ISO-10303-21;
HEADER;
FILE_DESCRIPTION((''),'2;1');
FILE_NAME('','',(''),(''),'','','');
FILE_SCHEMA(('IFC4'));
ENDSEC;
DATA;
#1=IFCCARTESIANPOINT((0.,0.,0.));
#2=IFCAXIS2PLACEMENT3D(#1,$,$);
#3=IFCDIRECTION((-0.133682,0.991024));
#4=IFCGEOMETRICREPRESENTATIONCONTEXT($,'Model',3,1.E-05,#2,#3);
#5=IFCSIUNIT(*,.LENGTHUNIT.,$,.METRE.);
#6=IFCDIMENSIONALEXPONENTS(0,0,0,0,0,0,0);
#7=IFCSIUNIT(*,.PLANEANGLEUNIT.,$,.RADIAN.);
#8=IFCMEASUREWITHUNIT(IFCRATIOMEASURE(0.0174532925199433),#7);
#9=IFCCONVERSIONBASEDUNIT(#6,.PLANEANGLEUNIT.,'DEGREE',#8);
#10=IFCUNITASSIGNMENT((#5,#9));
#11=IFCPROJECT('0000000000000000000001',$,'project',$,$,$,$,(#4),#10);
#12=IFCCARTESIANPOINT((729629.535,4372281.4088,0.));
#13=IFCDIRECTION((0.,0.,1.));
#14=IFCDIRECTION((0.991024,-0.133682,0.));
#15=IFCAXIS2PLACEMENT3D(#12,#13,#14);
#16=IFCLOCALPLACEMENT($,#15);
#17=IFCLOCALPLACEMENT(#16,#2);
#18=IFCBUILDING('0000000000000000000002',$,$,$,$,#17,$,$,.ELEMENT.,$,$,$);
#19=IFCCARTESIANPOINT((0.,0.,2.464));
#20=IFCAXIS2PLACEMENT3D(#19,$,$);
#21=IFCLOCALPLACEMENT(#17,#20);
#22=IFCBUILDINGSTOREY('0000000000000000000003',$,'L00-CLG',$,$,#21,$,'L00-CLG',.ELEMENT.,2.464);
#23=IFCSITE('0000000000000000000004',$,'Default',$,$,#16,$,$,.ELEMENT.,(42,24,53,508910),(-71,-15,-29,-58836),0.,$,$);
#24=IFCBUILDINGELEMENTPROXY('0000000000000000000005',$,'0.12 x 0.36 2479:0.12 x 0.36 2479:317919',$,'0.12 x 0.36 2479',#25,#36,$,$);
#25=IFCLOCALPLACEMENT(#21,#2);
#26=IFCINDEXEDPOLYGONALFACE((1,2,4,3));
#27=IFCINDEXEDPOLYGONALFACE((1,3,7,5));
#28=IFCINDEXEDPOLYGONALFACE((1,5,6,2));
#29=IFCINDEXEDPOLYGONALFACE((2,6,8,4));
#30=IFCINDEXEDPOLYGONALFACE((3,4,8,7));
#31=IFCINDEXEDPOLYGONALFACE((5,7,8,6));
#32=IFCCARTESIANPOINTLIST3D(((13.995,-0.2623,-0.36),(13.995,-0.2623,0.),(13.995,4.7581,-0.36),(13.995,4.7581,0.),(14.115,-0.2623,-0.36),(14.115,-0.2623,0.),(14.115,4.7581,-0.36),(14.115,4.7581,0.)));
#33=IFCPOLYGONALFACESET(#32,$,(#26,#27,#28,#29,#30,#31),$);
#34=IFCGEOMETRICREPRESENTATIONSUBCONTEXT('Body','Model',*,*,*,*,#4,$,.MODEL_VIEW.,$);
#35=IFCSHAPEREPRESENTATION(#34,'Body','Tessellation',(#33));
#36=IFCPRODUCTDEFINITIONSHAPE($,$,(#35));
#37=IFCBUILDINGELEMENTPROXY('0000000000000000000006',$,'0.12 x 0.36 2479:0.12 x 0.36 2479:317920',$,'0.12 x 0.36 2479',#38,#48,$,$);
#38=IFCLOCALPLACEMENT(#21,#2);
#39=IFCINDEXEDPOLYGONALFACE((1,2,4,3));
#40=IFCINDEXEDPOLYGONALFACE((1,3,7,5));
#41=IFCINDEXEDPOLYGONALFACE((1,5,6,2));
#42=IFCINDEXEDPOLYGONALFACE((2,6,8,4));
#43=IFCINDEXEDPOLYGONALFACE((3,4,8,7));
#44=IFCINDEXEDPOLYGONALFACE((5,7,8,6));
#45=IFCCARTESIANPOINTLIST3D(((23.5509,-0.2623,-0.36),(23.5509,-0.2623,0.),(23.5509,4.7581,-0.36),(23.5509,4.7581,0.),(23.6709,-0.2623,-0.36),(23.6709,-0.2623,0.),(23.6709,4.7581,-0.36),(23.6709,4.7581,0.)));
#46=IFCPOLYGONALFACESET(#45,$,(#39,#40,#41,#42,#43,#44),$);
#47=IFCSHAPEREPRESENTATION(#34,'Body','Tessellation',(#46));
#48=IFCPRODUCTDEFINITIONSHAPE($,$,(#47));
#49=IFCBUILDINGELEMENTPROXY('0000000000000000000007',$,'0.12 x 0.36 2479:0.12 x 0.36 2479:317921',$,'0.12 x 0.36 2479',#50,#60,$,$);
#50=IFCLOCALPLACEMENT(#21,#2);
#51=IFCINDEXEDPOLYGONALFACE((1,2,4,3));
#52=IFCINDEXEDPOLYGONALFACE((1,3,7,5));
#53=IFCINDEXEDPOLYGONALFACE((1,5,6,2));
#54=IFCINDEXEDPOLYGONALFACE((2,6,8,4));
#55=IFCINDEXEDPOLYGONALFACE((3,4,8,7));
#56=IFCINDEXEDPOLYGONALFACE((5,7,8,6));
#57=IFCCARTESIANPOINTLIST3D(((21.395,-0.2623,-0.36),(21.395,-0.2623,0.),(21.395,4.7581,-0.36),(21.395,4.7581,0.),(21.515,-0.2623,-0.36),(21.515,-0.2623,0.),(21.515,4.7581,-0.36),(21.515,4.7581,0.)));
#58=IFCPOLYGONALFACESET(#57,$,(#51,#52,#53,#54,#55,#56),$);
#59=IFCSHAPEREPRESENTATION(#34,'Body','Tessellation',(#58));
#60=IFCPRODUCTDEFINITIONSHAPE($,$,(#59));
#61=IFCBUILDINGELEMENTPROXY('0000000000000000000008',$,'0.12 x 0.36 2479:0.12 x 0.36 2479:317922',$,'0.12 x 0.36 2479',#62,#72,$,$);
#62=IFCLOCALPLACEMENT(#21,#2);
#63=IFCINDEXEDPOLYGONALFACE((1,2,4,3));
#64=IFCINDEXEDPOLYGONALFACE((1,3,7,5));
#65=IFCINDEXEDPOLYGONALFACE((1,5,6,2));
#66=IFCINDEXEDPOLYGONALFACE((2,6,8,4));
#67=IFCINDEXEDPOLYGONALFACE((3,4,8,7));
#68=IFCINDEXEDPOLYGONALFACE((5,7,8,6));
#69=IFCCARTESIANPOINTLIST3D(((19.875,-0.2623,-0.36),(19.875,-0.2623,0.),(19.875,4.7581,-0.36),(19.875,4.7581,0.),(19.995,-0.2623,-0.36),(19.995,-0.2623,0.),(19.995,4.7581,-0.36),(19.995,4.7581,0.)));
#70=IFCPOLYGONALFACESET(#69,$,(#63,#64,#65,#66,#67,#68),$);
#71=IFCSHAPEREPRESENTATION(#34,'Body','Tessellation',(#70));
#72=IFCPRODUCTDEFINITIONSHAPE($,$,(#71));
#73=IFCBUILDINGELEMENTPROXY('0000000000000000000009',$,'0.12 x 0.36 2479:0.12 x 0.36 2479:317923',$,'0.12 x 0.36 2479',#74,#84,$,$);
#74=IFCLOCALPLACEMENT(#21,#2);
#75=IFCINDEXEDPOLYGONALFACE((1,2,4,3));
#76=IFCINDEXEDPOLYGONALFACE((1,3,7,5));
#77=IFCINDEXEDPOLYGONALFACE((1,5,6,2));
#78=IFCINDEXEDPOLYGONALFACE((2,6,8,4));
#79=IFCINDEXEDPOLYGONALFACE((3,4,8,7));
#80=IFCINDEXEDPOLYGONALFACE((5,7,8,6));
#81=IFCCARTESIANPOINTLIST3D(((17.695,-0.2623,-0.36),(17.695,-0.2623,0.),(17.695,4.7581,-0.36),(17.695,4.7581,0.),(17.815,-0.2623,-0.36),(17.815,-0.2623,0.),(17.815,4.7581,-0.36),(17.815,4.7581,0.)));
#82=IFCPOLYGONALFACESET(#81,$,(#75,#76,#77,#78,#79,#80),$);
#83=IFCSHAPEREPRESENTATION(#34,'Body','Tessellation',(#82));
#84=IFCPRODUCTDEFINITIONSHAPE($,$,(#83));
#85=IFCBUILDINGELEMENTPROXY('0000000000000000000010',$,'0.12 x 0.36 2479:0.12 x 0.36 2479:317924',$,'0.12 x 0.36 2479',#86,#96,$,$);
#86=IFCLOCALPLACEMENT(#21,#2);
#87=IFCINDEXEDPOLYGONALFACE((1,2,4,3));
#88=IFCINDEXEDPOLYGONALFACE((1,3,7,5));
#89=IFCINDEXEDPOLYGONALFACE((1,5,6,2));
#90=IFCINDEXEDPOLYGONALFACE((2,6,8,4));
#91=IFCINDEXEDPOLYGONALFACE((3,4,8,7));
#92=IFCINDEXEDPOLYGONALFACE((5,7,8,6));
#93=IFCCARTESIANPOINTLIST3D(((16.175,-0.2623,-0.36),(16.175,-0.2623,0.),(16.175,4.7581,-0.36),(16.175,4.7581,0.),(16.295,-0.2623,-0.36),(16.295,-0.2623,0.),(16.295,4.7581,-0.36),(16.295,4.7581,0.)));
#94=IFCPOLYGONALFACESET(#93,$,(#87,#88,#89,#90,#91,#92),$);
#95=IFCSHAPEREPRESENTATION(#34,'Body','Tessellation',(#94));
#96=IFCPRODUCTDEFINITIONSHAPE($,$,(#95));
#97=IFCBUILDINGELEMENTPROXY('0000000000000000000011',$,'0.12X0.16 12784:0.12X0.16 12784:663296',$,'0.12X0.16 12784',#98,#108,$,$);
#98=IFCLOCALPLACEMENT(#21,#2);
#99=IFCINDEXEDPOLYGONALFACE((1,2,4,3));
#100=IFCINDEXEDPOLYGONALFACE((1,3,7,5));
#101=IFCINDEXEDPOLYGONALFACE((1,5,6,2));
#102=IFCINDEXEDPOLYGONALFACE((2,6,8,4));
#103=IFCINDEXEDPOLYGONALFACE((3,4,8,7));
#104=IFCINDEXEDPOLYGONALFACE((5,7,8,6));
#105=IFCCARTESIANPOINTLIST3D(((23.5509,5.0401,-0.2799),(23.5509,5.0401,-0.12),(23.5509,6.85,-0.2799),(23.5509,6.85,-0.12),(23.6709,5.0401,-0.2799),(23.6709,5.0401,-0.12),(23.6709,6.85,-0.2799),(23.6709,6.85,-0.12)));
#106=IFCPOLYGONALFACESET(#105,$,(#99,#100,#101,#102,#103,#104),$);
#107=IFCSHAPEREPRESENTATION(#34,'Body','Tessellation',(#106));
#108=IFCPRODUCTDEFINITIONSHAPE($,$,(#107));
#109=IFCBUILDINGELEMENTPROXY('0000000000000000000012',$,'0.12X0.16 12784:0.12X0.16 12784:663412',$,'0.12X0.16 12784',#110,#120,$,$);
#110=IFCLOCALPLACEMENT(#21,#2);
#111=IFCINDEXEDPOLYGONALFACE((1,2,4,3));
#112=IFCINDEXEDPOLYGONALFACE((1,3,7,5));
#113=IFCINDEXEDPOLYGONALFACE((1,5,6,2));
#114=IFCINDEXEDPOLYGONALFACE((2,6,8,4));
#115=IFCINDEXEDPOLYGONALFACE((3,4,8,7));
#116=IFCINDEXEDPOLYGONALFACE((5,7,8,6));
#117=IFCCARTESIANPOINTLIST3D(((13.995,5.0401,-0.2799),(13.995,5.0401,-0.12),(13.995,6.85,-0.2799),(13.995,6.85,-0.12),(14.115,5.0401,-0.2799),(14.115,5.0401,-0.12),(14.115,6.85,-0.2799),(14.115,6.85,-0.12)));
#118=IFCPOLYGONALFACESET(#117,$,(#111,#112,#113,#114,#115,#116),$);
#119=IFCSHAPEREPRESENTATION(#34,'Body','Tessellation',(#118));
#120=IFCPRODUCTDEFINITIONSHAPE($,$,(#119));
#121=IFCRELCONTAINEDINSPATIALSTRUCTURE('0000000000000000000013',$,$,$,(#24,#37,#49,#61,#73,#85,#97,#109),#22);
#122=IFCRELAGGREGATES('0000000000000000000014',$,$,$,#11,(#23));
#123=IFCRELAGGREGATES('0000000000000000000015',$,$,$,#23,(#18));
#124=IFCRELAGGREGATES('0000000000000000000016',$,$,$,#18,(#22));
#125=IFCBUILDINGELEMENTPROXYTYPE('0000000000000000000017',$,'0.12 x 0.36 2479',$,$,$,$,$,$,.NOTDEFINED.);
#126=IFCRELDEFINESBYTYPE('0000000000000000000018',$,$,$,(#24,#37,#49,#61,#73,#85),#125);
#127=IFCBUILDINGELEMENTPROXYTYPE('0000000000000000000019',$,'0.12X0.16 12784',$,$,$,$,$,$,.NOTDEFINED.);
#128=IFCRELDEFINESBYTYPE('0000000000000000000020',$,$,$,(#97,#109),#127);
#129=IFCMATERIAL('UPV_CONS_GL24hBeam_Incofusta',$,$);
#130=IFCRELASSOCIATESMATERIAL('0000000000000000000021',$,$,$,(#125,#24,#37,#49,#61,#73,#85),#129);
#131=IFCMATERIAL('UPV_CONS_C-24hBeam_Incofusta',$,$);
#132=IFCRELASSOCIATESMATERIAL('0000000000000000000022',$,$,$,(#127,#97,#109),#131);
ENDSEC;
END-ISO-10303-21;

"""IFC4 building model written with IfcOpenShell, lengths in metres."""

from ifc_helpers import new_model, entity, si_unit, converted_unit, direction, frame, frame_2d, origin, origin_2d_with_axis, place, context, subcontext, project, spatial, rectangle, extrude, source, transform, mapped, material, type_object, type_shapes, element, save


model = new_model("IFC4")

# Units and contexts
model_context = context("Model", 3, precision=1e-05, world=origin(), true_north=direction((-0.133682, 0.991024)))
body_context = subcontext(model_context, "Body", "Model", "MODEL_VIEW")
ifc_project = project(units=[si_unit("LENGTHUNIT", "METRE"), converted_unit("PLANEANGLEUNIT", "DEGREE", entity("IfcRatioMeasure", 0.0174532925199433), si_unit("PLANEANGLEUNIT", "RADIAN"), dimensions=[0, 0, 0, 0, 0, 0, 0])], contexts=[model_context])

# Site, building, storey
site_placement = place(None, frame((729629.535, 4372281.4088, 0.0), z_axis=(0.0, 0.0, 1.0), x_axis=(0.991024, -0.133682, 0.0)))
site = spatial("IfcSite", under=ifc_project, at=site_placement, Name="Default", CompositionType="ELEMENT", RefLatitude=(42, 24, 53, 508910), RefLongitude=(-71, -15, -29, -58836), RefElevation=0.0)
building_placement = place(site_placement, origin())
building = spatial("IfcBuilding", under=site, at=building_placement, CompositionType="ELEMENT")
storey_placement = place(building_placement, frame((0.0, 0.0, 2.464)))
storey = spatial("IfcBuildingStorey", under=building, at=storey_placement, Name="L00-CLG", LongName="L00-CLG", CompositionType="ELEMENT", Elevation=2.464)

# Building element proxies
ifc_material_1 = material(Name="UPV_CONS_GL24hBeam_Incofusta")
building_element_proxy_type_1 = type_object("IfcBuildingElementProxyType", Name="0.12 x 0.36 2479", material=ifc_material_1)
shared_shape_1 = source(origin(), body_context, "Body", "SweptSolid", [
    extrude(rectangle(XDim=0.12, YDim=5.0204, at=origin_2d_with_axis()), frame((0.0, 0.0, -0.18), z_axis=(0.0, 0.0, 1.0), x_axis=(0.0, -1.0, 0.0)), (0.0, 0.0, 1.0), 0.36),
])
type_shapes(building_element_proxy_type_1, [shared_shape_1])
for number, where, z_axis, x_axis, name in (
    (1, (14.055, 2.2479, -0.18), (0.0, 0.0, 1.0), (0.0, 1.0, 0.0), "0.12 x 0.36 2479:0.12 x 0.36 2479:317919"),
    (2, (23.6109, 2.2479, -0.18), (0.0, 0.0, 1.0), (0.0, 1.0, 0.0), "0.12 x 0.36 2479:0.12 x 0.36 2479:317920"),
    (3, (21.455, 2.2479, -0.18), (0.0, 0.0, 1.0), (0.0, 1.0, 0.0), "0.12 x 0.36 2479:0.12 x 0.36 2479:317921"),
    (4, (19.935, 2.2479, -0.18), (0.0, 0.0, 1.0), (0.0, 1.0, 0.0), "0.12 x 0.36 2479:0.12 x 0.36 2479:317922"),
    (5, (17.755, 2.2479, -0.18), (0.0, 0.0, 1.0), (0.0, 1.0, 0.0), "0.12 x 0.36 2479:0.12 x 0.36 2479:317923"),
    (6, (16.235, 2.2479, -0.18), (0.0, 0.0, 1.0), (0.0, 1.0, 0.0), "0.12 x 0.36 2479:0.12 x 0.36 2479:317924"),
):
    element("IfcBuildingElementProxy", number, at=place(storey_placement, frame(where, z_axis=z_axis, x_axis=x_axis)), inside=storey, type_object=building_element_proxy_type_1, material=ifc_material_1, Name=name, ObjectType="0.12 x 0.36 2479", context=body_context, shape_type="MappedRepresentation", body=[
        mapped(shared_shape_1, transform((0.0, 0.0, 0.0), scale=1.0)),
    ])
ifc_material_2 = material(Name="UPV_CONS_C-24hBeam_Incofusta")
building_element_proxy_type_2 = type_object("IfcBuildingElementProxyType", Name="0.12X0.16 12784", material=ifc_material_2)
shared_shape_2 = source(origin(), body_context, "Body", "SweptSolid", [
    extrude(rectangle(XDim=0.12, YDim=1.8099, at=frame_2d((0.0, 0.0), x_axis=(1.0, 0.0))), frame((0.9049, 0.06, 0.0), z_axis=(0.0, 0.0, 1.0), x_axis=(0.0, -1.0, 0.0)), (0.0, 0.0, 1.0), 0.1599),
])
type_shapes(building_element_proxy_type_2, [shared_shape_2])
for number, where, z_axis, x_axis, name in (
    (7, (23.6709, 5.0401, -0.2799), (0.0, 0.0, 1.0), (0.0, 1.0, 0.0), "0.12X0.16 12784:0.12X0.16 12784:663296"),
    (8, (14.115, 5.0401, -0.2799), (0.0, 0.0, 1.0), (0.0, 1.0, 0.0), "0.12X0.16 12784:0.12X0.16 12784:663412"),
):
    element("IfcBuildingElementProxy", number, at=place(storey_placement, frame(where, z_axis=z_axis, x_axis=x_axis)), inside=storey, type_object=building_element_proxy_type_2, material=ifc_material_2, Name=name, ObjectType="0.12X0.16 12784", context=body_context, shape_type="MappedRepresentation", body=[
        mapped(shared_shape_2, transform((0.0, 0.0, 0.0), scale=1.0)),
    ])

save(model, "model.ifc")
